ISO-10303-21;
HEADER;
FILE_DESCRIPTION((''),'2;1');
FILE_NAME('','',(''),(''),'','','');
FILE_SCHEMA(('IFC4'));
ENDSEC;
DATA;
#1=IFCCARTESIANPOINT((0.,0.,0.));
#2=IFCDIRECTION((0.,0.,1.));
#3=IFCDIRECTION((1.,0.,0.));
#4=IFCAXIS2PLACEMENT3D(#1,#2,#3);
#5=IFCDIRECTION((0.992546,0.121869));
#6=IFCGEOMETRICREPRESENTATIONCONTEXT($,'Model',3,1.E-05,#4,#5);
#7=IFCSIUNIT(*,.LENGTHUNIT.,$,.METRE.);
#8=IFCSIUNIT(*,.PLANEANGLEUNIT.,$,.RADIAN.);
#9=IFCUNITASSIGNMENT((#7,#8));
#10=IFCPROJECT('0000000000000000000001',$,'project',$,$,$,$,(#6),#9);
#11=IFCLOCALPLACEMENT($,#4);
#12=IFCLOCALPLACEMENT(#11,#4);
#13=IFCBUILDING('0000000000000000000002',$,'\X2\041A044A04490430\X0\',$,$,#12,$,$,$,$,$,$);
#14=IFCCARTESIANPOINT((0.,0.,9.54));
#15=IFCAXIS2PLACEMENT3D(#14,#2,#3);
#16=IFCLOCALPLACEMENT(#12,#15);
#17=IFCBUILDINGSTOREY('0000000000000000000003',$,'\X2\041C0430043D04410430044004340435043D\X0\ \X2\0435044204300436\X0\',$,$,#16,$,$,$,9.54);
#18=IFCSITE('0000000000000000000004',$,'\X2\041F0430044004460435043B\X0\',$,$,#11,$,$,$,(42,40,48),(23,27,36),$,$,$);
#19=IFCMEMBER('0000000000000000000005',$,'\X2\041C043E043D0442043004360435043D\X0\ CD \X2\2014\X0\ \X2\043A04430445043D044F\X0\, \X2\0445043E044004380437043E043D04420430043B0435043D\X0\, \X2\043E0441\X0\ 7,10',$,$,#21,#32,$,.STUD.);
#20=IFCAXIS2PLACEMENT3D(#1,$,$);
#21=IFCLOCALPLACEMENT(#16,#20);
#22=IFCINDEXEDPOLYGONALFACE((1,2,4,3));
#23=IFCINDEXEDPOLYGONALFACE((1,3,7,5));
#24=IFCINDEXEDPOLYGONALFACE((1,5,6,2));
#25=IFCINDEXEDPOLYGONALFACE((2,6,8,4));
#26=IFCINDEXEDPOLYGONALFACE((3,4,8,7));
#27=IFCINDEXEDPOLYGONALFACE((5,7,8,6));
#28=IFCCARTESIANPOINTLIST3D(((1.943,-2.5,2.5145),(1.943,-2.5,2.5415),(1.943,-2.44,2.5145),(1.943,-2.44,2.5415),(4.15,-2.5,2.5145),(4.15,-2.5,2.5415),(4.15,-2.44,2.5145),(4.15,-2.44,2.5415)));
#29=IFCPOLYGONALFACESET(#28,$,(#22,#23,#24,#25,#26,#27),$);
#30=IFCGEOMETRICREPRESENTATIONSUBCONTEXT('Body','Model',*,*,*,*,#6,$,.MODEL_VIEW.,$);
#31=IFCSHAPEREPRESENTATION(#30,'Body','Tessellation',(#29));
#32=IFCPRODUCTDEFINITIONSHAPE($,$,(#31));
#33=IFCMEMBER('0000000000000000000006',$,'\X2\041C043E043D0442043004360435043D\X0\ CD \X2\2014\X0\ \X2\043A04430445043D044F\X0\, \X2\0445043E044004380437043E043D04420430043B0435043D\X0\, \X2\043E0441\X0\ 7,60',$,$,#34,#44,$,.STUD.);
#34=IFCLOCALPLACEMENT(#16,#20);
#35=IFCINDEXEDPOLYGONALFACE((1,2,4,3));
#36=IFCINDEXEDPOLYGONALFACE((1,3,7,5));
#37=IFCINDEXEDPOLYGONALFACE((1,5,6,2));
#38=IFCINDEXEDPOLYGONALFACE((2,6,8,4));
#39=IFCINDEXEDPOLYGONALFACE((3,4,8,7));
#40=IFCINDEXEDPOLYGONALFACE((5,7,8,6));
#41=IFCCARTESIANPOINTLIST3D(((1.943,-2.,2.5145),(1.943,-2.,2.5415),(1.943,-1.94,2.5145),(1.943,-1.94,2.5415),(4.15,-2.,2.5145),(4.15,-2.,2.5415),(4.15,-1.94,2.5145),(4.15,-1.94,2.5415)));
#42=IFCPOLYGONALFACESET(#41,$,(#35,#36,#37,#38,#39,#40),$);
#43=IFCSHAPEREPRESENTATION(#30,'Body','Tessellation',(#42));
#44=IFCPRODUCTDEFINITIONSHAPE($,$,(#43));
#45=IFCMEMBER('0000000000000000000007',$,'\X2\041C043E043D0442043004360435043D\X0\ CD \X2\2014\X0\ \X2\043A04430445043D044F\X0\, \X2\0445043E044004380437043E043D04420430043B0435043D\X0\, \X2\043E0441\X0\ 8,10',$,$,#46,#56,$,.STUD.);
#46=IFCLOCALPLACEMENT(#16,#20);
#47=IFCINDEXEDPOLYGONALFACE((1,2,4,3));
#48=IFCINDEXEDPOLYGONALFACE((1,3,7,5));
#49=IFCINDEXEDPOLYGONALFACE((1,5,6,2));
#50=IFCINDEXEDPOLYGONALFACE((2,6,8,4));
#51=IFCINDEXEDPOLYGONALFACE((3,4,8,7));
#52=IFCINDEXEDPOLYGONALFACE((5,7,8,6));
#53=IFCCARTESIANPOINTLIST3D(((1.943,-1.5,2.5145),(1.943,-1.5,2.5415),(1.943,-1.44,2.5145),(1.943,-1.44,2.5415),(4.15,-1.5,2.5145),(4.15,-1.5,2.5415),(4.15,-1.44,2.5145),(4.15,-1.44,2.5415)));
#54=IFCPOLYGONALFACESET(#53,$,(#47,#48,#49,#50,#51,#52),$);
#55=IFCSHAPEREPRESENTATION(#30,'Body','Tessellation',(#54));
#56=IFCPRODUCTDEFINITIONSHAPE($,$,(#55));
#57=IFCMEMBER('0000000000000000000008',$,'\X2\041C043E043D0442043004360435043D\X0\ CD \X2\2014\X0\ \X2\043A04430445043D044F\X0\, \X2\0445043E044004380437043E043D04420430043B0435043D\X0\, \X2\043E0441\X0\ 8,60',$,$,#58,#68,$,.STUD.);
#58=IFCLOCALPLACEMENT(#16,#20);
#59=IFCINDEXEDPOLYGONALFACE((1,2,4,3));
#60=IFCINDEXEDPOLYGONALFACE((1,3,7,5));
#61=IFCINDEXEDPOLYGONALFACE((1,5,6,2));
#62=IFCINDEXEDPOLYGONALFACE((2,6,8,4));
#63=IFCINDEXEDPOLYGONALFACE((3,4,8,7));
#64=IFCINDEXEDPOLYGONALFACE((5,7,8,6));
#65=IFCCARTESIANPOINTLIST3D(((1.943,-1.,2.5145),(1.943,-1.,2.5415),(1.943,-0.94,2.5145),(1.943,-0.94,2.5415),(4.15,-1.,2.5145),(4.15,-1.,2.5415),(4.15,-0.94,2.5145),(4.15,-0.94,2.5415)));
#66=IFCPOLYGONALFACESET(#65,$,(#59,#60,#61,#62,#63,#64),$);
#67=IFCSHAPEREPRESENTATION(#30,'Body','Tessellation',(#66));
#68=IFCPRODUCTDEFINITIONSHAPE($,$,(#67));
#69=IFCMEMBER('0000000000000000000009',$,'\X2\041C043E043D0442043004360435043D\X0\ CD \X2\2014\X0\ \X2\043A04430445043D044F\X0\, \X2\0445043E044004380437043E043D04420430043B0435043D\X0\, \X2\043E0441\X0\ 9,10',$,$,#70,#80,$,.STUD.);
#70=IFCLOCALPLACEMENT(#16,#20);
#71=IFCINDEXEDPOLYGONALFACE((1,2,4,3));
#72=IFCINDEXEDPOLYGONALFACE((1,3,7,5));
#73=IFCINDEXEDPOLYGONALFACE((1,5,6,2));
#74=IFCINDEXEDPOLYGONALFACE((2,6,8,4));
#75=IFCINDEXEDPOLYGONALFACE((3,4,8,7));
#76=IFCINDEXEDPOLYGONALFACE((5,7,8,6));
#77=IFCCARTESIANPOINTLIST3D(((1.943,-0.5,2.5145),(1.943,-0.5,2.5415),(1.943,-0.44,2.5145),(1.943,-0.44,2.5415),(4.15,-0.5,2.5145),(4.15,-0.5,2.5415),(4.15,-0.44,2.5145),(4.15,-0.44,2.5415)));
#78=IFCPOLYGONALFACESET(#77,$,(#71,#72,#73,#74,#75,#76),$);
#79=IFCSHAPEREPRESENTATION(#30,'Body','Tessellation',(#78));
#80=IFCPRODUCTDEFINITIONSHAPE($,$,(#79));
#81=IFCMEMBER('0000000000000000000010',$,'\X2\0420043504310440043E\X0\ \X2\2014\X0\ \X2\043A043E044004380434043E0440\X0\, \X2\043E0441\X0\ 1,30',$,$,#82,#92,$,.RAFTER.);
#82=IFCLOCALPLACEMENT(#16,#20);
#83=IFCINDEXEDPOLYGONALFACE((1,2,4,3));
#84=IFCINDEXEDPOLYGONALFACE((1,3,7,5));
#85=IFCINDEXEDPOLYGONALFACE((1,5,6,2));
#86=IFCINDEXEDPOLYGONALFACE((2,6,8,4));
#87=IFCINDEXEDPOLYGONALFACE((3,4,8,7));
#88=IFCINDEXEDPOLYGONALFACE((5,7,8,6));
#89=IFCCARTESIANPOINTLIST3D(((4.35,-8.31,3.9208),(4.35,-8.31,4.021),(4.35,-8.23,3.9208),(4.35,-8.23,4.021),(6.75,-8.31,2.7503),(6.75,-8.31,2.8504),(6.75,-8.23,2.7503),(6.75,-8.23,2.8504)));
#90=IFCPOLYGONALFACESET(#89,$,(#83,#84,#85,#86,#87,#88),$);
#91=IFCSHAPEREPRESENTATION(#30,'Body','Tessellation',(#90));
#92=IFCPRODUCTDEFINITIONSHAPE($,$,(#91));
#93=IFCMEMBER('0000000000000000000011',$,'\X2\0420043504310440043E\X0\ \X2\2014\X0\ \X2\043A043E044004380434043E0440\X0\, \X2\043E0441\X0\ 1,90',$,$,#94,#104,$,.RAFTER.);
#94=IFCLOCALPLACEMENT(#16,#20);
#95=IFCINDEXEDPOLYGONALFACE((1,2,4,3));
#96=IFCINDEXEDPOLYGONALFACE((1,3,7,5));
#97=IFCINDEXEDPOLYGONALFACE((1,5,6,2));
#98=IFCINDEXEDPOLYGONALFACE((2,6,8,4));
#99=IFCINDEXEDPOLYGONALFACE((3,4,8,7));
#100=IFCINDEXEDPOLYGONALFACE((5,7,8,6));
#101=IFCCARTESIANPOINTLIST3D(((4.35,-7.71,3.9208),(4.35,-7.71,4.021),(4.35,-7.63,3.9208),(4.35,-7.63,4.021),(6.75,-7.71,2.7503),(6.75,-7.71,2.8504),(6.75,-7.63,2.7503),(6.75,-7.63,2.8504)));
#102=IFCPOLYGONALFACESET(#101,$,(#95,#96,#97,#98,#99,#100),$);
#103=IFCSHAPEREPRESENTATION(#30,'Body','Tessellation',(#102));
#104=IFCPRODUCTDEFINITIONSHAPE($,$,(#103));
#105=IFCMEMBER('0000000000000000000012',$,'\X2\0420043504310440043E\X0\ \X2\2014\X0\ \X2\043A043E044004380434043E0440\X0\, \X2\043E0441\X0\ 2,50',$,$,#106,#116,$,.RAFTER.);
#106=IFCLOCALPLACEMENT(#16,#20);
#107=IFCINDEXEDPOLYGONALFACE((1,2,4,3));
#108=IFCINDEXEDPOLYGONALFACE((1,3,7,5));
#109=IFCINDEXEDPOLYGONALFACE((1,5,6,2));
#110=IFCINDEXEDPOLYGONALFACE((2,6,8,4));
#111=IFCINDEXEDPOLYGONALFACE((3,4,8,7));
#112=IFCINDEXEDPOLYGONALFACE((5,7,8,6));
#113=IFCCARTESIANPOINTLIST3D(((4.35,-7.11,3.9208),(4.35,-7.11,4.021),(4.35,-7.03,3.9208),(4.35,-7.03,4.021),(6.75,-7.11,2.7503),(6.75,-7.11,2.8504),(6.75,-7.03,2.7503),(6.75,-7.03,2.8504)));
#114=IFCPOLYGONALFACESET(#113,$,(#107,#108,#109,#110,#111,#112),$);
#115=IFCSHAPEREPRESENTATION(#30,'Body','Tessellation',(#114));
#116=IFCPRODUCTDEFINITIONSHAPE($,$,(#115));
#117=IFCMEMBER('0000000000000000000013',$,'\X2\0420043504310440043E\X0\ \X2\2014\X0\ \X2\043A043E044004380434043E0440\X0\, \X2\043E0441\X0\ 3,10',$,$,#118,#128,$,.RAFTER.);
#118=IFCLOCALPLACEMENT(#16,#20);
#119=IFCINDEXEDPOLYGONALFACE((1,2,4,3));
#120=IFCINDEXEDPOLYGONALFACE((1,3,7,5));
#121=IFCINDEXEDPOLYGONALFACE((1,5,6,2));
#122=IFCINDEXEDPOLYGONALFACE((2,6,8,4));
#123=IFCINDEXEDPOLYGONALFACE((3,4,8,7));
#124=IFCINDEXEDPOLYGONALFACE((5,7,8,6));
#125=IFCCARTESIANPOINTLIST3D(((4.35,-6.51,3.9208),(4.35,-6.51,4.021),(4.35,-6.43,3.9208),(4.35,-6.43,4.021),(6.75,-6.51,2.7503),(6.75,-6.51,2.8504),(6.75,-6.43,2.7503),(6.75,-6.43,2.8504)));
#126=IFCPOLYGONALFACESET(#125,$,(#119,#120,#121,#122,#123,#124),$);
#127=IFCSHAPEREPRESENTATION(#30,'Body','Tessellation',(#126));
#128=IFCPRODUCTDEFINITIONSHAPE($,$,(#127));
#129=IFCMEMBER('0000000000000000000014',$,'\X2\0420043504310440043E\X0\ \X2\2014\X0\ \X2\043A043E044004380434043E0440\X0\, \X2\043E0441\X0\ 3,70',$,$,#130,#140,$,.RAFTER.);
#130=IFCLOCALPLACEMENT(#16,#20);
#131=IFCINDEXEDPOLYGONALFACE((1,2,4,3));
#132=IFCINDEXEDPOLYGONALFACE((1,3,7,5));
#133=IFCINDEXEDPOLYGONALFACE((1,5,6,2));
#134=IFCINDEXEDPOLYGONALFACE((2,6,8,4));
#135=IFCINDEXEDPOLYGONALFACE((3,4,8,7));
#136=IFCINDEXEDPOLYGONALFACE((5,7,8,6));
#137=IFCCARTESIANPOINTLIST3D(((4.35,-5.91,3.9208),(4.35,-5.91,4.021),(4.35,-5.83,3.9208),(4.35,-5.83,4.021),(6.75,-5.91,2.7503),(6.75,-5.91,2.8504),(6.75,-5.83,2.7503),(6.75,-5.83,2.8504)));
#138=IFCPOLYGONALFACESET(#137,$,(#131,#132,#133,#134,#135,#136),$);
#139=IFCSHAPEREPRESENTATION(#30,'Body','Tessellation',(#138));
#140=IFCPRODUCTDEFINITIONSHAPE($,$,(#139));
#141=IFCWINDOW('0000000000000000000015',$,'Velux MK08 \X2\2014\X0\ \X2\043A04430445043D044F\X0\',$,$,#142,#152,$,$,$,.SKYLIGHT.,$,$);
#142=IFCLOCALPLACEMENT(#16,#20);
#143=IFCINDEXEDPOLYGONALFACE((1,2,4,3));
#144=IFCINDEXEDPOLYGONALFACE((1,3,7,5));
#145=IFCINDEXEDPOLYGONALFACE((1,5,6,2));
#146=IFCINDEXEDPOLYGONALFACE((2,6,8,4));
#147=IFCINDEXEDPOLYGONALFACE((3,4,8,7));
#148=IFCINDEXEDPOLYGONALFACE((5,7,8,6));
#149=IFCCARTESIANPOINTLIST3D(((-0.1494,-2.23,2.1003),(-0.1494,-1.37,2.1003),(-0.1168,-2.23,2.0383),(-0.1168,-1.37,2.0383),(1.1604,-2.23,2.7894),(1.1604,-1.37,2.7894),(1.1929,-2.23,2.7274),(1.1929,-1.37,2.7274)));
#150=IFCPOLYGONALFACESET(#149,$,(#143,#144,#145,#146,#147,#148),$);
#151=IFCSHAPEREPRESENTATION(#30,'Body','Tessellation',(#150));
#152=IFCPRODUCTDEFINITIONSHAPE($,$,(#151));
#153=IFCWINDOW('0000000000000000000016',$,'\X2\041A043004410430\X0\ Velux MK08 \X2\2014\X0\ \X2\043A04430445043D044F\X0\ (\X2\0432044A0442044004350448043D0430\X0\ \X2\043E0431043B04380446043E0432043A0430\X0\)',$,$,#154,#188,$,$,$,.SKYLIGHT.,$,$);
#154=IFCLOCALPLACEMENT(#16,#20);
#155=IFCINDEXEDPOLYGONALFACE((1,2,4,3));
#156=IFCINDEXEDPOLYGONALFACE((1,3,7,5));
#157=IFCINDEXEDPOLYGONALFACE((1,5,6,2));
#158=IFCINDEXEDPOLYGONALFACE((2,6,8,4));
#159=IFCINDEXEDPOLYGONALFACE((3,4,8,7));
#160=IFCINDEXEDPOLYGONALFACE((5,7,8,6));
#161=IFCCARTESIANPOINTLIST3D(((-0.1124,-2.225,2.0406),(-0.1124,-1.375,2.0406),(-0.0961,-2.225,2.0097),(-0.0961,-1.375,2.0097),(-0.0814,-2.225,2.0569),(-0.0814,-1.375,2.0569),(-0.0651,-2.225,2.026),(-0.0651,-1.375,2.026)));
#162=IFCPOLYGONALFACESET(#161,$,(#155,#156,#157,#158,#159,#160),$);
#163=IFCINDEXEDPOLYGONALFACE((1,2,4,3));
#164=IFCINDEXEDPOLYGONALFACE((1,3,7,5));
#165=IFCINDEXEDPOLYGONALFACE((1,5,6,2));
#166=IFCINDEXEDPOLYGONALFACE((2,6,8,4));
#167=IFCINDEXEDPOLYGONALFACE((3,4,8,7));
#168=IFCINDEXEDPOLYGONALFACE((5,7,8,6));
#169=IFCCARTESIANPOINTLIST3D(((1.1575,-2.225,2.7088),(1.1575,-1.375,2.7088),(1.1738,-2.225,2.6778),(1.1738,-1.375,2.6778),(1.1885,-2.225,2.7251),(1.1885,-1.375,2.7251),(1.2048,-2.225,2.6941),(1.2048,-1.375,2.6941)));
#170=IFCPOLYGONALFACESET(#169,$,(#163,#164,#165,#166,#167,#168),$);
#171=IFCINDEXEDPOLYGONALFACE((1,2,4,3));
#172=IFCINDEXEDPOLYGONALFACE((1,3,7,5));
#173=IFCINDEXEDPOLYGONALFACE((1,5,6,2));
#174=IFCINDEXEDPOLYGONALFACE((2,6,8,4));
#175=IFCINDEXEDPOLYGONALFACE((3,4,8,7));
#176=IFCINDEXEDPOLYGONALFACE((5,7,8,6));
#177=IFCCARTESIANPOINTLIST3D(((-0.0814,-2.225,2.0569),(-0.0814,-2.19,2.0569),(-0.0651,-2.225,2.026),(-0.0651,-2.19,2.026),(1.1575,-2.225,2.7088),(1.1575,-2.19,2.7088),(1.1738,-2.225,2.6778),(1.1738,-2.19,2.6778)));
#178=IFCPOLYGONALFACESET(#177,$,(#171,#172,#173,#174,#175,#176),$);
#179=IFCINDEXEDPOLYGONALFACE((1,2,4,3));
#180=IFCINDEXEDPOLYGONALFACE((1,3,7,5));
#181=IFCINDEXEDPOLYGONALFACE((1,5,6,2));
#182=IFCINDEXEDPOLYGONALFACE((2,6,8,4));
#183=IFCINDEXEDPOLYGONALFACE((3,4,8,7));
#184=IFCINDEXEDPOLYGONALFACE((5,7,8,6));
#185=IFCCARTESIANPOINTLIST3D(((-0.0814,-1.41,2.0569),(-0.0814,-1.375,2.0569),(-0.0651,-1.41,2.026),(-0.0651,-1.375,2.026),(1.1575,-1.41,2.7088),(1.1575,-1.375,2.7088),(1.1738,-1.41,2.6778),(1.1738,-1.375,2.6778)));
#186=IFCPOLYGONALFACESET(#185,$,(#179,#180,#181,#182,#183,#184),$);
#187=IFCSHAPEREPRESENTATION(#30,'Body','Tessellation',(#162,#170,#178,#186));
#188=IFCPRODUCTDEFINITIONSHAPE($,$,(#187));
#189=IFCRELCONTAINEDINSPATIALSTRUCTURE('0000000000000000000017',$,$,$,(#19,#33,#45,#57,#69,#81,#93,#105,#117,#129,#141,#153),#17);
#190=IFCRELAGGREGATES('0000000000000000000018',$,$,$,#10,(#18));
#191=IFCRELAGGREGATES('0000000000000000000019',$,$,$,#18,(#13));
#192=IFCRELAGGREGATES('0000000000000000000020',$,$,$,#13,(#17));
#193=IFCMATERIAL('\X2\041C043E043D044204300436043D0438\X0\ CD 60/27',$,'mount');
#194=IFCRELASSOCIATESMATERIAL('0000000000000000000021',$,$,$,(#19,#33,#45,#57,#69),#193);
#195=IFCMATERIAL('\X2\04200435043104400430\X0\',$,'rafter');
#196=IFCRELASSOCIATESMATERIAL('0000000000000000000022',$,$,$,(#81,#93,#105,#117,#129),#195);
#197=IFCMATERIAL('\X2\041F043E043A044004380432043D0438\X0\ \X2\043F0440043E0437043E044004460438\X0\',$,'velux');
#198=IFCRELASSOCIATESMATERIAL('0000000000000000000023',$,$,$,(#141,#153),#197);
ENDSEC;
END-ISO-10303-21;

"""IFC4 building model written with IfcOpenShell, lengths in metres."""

from ifc_helpers import new_model, si_unit, direction, frame, origin_with_axes, place, context, subcontext, project, spatial, polyline, outline, extrude, material, element, save


model = new_model("IFC4")

# Units and contexts
model_context = context("Model", 3, precision=1e-05, world=origin_with_axes(), true_north=direction((0.992546, 0.121869)))
body_context = subcontext(model_context, "Body", "Model", "MODEL_VIEW")
ifc_project = project(units=[si_unit("LENGTHUNIT", "METRE"), si_unit("PLANEANGLEUNIT", "RADIAN")], contexts=[model_context])

# Site, building, storey
site_placement = place(None, origin_with_axes())
site = spatial("IfcSite", under=ifc_project, at=site_placement, Name="Парцел", RefLatitude=(42, 40, 48), RefLongitude=(23, 27, 36))
building_placement = place(site_placement, origin_with_axes())
building = spatial("IfcBuilding", under=site, at=building_placement, Name="Къща")
storey_placement = place(building_placement, frame((0.0, 0.0, 9.54), z_axis=(0.0, 0.0, 1.0), x_axis=(1.0, 0.0, 0.0)))
storey = spatial("IfcBuildingStorey", under=building, at=storey_placement, Name="Мансарден етаж", Elevation=9.54)

# Shared definitions
ifc_material_1 = material(Name="Монтажни CD 60/27", Category="mount")

# Members
member_1_placement = place(storey_placement, origin_with_axes())
element("IfcMember", 1, at=member_1_placement, inside=storey, material=ifc_material_1, Name="Монтажен CD — кухня, хоризонтален, ос 7,10", PredefinedType="STUD", context=body_context, shape_type="SweptSolid", body=[
    extrude(outline(polyline([(1.943, -2.5145), (4.15, -2.5145), (4.15, -2.5415), (1.943, -2.5415), (1.943, -2.5145)])), frame((0.0, -2.5, 0.0), z_axis=(0.0, 1.0, 0.0), x_axis=(1.0, 0.0, 0.0)), (0.0, 0.0, 1.0), 0.06),
])
member_2_placement = place(storey_placement, origin_with_axes())
element("IfcMember", 2, at=member_2_placement, inside=storey, material=ifc_material_1, Name="Монтажен CD — кухня, хоризонтален, ос 7,60", PredefinedType="STUD", context=body_context, shape_type="SweptSolid", body=[
    extrude(outline(polyline([(1.943, -2.5145), (4.15, -2.5145), (4.15, -2.5415), (1.943, -2.5415), (1.943, -2.5145)])), frame((0.0, -2.0, 0.0), z_axis=(0.0, 1.0, 0.0), x_axis=(1.0, 0.0, 0.0)), (0.0, 0.0, 1.0), 0.06),
])
member_3_placement = place(storey_placement, origin_with_axes())
element("IfcMember", 3, at=member_3_placement, inside=storey, material=ifc_material_1, Name="Монтажен CD — кухня, хоризонтален, ос 8,10", PredefinedType="STUD", context=body_context, shape_type="SweptSolid", body=[
    extrude(outline(polyline([(1.943, -2.5145), (4.15, -2.5145), (4.15, -2.5415), (1.943, -2.5415), (1.943, -2.5145)])), frame((0.0, -1.5, 0.0), z_axis=(0.0, 1.0, 0.0), x_axis=(1.0, 0.0, 0.0)), (0.0, 0.0, 1.0), 0.06),
])
member_4_placement = place(storey_placement, origin_with_axes())
element("IfcMember", 4, at=member_4_placement, inside=storey, material=ifc_material_1, Name="Монтажен CD — кухня, хоризонтален, ос 8,60", PredefinedType="STUD", context=body_context, shape_type="SweptSolid", body=[
    extrude(outline(polyline([(1.943, -2.5145), (4.15, -2.5145), (4.15, -2.5415), (1.943, -2.5415), (1.943, -2.5145)])), frame((0.0, -1.0, 0.0), z_axis=(0.0, 1.0, 0.0), x_axis=(1.0, 0.0, 0.0)), (0.0, 0.0, 1.0), 0.06),
])
member_5_placement = place(storey_placement, origin_with_axes())
element("IfcMember", 5, at=member_5_placement, inside=storey, material=ifc_material_1, Name="Монтажен CD — кухня, хоризонтален, ос 9,10", PredefinedType="STUD", context=body_context, shape_type="SweptSolid", body=[
    extrude(outline(polyline([(1.943, -2.5145), (4.15, -2.5145), (4.15, -2.5415), (1.943, -2.5415), (1.943, -2.5145)])), frame((0.0, -0.5, 0.0), z_axis=(0.0, 1.0, 0.0), x_axis=(1.0, 0.0, 0.0)), (0.0, 0.0, 1.0), 0.06),
])
ifc_material_2 = material(Name="Ребра", Category="rafter")
member_6_placement = place(storey_placement, origin_with_axes())
element("IfcMember", 6, at=member_6_placement, inside=storey, material=ifc_material_2, Name="Ребро — коридор, ос 1,30", PredefinedType="RAFTER", context=body_context, shape_type="SweptSolid", body=[
    extrude(outline(polyline([(6.75, -2.7503), (4.35, -3.9208), (4.35, -4.021), (6.75, -2.8504), (6.75, -2.7503)])), frame((0.0, -8.31, 0.0), z_axis=(0.0, 1.0, 0.0), x_axis=(1.0, 0.0, 0.0)), (0.0, 0.0, 1.0), 0.08),
])
member_7_placement = place(storey_placement, origin_with_axes())
element("IfcMember", 7, at=member_7_placement, inside=storey, material=ifc_material_2, Name="Ребро — коридор, ос 1,90", PredefinedType="RAFTER", context=body_context, shape_type="SweptSolid", body=[
    extrude(outline(polyline([(6.75, -2.7503), (4.35, -3.9208), (4.35, -4.021), (6.75, -2.8504), (6.75, -2.7503)])), frame((0.0, -7.71, 0.0), z_axis=(0.0, 1.0, 0.0), x_axis=(1.0, 0.0, 0.0)), (0.0, 0.0, 1.0), 0.08),
])
member_8_placement = place(storey_placement, origin_with_axes())
element("IfcMember", 8, at=member_8_placement, inside=storey, material=ifc_material_2, Name="Ребро — коридор, ос 2,50", PredefinedType="RAFTER", context=body_context, shape_type="SweptSolid", body=[
    extrude(outline(polyline([(6.75, -2.7503), (4.35, -3.9208), (4.35, -4.021), (6.75, -2.8504), (6.75, -2.7503)])), frame((0.0, -7.11, 0.0), z_axis=(0.0, 1.0, 0.0), x_axis=(1.0, 0.0, 0.0)), (0.0, 0.0, 1.0), 0.08),
])
member_9_placement = place(storey_placement, origin_with_axes())
element("IfcMember", 9, at=member_9_placement, inside=storey, material=ifc_material_2, Name="Ребро — коридор, ос 3,10", PredefinedType="RAFTER", context=body_context, shape_type="SweptSolid", body=[
    extrude(outline(polyline([(6.75, -2.7503), (4.35, -3.9208), (4.35, -4.021), (6.75, -2.8504), (6.75, -2.7503)])), frame((0.0, -6.51, 0.0), z_axis=(0.0, 1.0, 0.0), x_axis=(1.0, 0.0, 0.0)), (0.0, 0.0, 1.0), 0.08),
])
member_10_placement = place(storey_placement, origin_with_axes())
element("IfcMember", 10, at=member_10_placement, inside=storey, material=ifc_material_2, Name="Ребро — коридор, ос 3,70", PredefinedType="RAFTER", context=body_context, shape_type="SweptSolid", body=[
    extrude(outline(polyline([(6.75, -2.7503), (4.35, -3.9208), (4.35, -4.021), (6.75, -2.8504), (6.75, -2.7503)])), frame((0.0, -5.91, 0.0), z_axis=(0.0, 1.0, 0.0), x_axis=(1.0, 0.0, 0.0)), (0.0, 0.0, 1.0), 0.08),
])

# Windows
ifc_material_3 = material(Name="Покривни прозорци", Category="velux")
window_1_placement = place(storey_placement, origin_with_axes())
element("IfcWindow", 11, at=window_1_placement, inside=storey, material=ifc_material_3, Name="Velux MK08 — кухня", PredefinedType="SKYLIGHT", context=body_context, shape_type="SweptSolid", body=[
    extrude(outline(polyline([(-0.1168, -2.0383), (1.1929, -2.7274), (1.1604, -2.7894), (-0.1494, -2.1003), (-0.1168, -2.0383)])), frame((0.0, -2.23, 0.0), z_axis=(0.0, 1.0, 0.0), x_axis=(1.0, 0.0, 0.0)), (0.0, 0.0, 1.0), 0.86),
])
window_2_placement = place(storey_placement, origin_with_axes())
element("IfcWindow", 12, at=window_2_placement, inside=storey, material=ifc_material_3, Name="Каса Velux MK08 — кухня (вътрешна облицовка)", PredefinedType="SKYLIGHT", context=body_context, shape_type="SweptSolid", body=[
    extrude(outline(polyline([(-0.0961, -2.0097), (-0.0651, -2.026), (-0.0814, -2.0569), (-0.1124, -2.0406), (-0.0961, -2.0097)])), frame((0.0, -2.225, 0.0), z_axis=(0.0, 1.0, 0.0), x_axis=(1.0, 0.0, 0.0)), (0.0, 0.0, 1.0), 0.85),
    extrude(outline(polyline([(1.1738, -2.6778), (1.2048, -2.6941), (1.1885, -2.7251), (1.1575, -2.7088), (1.1738, -2.6778)])), frame((0.0, -2.225, 0.0), z_axis=(0.0, 1.0, 0.0), x_axis=(1.0, 0.0, 0.0)), (0.0, 0.0, 1.0), 0.85),
    extrude(outline(polyline([(-0.0651, -2.026), (1.1738, -2.6778), (1.1575, -2.7088), (-0.0814, -2.0569), (-0.0651, -2.026)])), frame((0.0, -2.225, 0.0), z_axis=(0.0, 1.0, 0.0), x_axis=(1.0, 0.0, 0.0)), (0.0, 0.0, 1.0), 0.035),
    extrude(outline(polyline([(-0.0651, -2.026), (1.1738, -2.6778), (1.1575, -2.7088), (-0.0814, -2.0569), (-0.0651, -2.026)])), frame((0.0, -1.41, 0.0), z_axis=(0.0, 1.0, 0.0), x_axis=(1.0, 0.0, 0.0)), (0.0, 0.0, 1.0), 0.035),
])

save(model, "model.ifc")
